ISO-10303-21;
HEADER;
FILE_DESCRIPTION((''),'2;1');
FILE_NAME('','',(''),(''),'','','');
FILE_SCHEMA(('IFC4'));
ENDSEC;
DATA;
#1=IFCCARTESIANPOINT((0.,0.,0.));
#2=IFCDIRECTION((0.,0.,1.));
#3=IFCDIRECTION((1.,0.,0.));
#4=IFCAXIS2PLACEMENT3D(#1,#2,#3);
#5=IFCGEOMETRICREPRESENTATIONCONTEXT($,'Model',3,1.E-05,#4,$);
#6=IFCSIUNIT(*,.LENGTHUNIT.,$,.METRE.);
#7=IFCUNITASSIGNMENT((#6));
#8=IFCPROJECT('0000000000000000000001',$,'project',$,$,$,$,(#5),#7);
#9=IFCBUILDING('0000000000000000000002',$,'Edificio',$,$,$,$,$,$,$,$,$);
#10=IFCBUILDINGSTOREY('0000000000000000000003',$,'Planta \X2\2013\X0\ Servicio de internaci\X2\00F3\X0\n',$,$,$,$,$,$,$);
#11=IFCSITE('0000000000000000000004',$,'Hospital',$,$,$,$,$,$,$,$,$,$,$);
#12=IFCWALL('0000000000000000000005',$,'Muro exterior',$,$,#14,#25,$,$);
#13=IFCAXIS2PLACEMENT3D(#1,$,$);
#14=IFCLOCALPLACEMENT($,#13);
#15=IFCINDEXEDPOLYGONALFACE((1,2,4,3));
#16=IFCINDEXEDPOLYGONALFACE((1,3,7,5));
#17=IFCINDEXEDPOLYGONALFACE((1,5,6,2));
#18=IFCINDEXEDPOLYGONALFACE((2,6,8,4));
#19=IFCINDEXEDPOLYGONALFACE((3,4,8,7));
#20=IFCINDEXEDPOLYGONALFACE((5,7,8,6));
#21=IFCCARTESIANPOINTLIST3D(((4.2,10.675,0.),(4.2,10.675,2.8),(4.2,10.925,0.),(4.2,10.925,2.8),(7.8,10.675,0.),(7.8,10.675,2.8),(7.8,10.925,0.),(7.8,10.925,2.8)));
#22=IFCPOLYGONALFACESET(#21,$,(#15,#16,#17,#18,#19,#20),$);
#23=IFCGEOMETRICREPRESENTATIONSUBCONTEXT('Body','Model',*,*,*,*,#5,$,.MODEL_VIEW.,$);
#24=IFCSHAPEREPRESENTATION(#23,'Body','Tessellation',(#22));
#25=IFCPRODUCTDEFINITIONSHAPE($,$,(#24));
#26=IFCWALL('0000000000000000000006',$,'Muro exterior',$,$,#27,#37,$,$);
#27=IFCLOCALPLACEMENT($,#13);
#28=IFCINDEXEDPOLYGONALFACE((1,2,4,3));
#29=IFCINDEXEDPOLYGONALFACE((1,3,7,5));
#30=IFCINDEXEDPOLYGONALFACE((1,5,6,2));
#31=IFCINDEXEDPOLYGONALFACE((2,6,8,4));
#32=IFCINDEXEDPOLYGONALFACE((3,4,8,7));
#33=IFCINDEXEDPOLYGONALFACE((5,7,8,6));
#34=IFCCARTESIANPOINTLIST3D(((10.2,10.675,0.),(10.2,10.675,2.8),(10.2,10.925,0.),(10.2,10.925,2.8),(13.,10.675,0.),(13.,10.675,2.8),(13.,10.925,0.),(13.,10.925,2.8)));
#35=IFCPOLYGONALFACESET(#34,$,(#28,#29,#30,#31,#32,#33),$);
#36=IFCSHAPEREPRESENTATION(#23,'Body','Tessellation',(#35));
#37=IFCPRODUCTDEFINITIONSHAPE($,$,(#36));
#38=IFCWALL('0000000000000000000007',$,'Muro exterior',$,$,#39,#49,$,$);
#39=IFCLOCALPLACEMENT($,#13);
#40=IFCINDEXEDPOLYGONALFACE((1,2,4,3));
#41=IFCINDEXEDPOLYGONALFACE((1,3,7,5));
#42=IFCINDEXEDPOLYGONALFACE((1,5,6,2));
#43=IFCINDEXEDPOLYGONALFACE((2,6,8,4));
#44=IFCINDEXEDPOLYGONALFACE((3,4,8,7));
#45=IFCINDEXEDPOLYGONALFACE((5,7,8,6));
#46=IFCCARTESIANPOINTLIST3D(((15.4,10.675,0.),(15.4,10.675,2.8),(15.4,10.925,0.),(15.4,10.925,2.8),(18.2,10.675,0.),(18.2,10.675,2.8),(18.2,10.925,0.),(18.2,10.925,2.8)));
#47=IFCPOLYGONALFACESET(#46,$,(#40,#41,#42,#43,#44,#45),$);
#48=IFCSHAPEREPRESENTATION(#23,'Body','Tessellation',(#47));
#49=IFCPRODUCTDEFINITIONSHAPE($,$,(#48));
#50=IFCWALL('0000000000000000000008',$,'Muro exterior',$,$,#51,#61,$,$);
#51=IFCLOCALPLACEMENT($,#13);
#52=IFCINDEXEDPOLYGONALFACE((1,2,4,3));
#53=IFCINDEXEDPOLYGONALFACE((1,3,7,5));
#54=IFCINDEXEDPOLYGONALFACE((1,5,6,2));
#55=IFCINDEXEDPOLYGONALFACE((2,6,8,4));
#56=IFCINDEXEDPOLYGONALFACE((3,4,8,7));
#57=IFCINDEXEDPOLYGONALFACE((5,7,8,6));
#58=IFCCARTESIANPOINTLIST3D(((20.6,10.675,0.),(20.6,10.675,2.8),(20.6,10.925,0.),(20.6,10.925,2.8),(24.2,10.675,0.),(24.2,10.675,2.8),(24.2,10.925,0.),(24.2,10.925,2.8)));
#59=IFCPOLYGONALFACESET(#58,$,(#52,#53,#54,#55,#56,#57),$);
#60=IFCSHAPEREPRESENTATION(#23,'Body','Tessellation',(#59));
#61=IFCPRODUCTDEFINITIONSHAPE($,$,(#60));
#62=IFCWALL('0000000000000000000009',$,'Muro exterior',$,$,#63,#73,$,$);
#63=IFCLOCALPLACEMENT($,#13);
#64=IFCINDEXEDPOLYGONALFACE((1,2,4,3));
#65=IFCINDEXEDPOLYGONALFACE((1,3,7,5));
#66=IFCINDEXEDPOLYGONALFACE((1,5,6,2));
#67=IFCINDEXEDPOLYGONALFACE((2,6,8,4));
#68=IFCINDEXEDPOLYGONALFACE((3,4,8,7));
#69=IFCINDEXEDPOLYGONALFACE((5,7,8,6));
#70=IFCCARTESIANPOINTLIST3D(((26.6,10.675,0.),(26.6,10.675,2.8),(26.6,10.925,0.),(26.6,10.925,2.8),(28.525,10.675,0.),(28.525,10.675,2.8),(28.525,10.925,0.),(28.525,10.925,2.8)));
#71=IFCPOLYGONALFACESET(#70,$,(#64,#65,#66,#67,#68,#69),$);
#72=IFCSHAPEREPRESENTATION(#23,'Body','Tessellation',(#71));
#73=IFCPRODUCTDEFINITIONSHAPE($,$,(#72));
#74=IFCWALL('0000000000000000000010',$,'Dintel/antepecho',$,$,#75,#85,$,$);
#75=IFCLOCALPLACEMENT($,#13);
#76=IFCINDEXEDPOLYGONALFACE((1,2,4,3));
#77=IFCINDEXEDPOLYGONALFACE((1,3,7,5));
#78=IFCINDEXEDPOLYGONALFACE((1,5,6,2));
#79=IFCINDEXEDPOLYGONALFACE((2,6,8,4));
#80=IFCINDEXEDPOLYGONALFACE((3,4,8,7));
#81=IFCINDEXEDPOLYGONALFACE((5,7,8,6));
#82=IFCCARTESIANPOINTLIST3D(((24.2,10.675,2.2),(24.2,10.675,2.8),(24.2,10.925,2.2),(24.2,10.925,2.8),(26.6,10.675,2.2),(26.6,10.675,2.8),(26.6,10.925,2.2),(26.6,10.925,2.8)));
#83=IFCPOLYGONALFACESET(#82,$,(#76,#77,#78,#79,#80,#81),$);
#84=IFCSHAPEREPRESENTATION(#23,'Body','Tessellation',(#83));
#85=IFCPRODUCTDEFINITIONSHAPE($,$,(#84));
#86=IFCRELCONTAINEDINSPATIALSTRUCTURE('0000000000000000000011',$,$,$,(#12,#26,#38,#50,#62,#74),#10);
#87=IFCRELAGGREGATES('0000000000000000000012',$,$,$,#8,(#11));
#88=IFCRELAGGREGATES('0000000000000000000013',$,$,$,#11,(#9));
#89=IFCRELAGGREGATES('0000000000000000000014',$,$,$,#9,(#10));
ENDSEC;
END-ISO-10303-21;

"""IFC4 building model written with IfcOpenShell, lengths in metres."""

from ifc_helpers import new_model, si_unit, frame, origin_with_axes, context, subcontext, project, spatial, line, indexed_curve, outline, extrude, element, save


model = new_model("IFC4")

# Units and contexts
model_context = context("Model", 3, precision=1e-05, world=origin_with_axes())
body_context = subcontext(model_context, "Body", "Model", "MODEL_VIEW")
ifc_project = project(units=[si_unit("LENGTHUNIT", "METRE")], contexts=[model_context])

# Site, building, storey
site = spatial("IfcSite", under=ifc_project, Name="Hospital")
building = spatial("IfcBuilding", under=site, Name="Edificio")
storey = spatial("IfcBuildingStorey", under=building, Name="Planta – Servicio de internación")

# Walls
element("IfcWall", 1, inside=storey, Name="Muro exterior", context=body_context, shape_type="SweptSolid", body=[
    extrude(outline(indexed_curve([(0.0, 0.0), (3.6, 0.0), (3.6, 0.25), (0.0, 0.25)], segments=[line(1, 2, 3, 4, 1)])), frame((4.2, 10.675, 0.0), z_axis=(0.0, 0.0, 1.0), x_axis=(1.0, 0.0, 0.0)), (0.0, 0.0, 1.0), 2.8),
])
element("IfcWall", 2, inside=storey, Name="Muro exterior", context=body_context, shape_type="SweptSolid", body=[
    extrude(outline(indexed_curve([(0.0, 0.0), (2.8, 0.0), (2.8, 0.25), (0.0, 0.25)], segments=[line(1, 2, 3, 4, 1)])), frame((10.2, 10.675, 0.0), z_axis=(0.0, 0.0, 1.0), x_axis=(1.0, 0.0, 0.0)), (0.0, 0.0, 1.0), 2.8),
])
element("IfcWall", 3, inside=storey, Name="Muro exterior", context=body_context, shape_type="SweptSolid", body=[
    extrude(outline(indexed_curve([(0.0, 0.0), (2.8, 0.0), (2.8, 0.25), (0.0, 0.25)], segments=[line(1, 2, 3, 4, 1)])), frame((15.4, 10.675, 0.0), z_axis=(0.0, 0.0, 1.0), x_axis=(1.0, 0.0, 0.0)), (0.0, 0.0, 1.0), 2.8),
])
element("IfcWall", 4, inside=storey, Name="Muro exterior", context=body_context, shape_type="SweptSolid", body=[
    extrude(outline(indexed_curve([(0.0, 0.0), (3.6, 0.0), (3.6, 0.25), (0.0, 0.25)], segments=[line(1, 2, 3, 4, 1)])), frame((20.6, 10.675, 0.0), z_axis=(0.0, 0.0, 1.0), x_axis=(1.0, 0.0, 0.0)), (0.0, 0.0, 1.0), 2.8),
])
element("IfcWall", 5, inside=storey, Name="Muro exterior", context=body_context, shape_type="SweptSolid", body=[
    extrude(outline(indexed_curve([(0.0, 0.0), (1.925, 0.0), (1.925, 0.25), (0.0, 0.25)], segments=[line(1, 2, 3, 4, 1)])), frame((26.6, 10.675, 0.0), z_axis=(0.0, 0.0, 1.0), x_axis=(1.0, 0.0, 0.0)), (0.0, 0.0, 1.0), 2.8),
])
element("IfcWall", 6, inside=storey, Name="Dintel/antepecho", context=body_context, shape_type="SweptSolid", body=[
    extrude(outline(indexed_curve([(0.0, 0.0), (2.4, 0.0), (2.4, 0.25), (0.0, 0.25)], segments=[line(1, 2, 3, 4, 1)])), frame((24.2, 10.675, 2.2), z_axis=(0.0, 0.0, 1.0), x_axis=(1.0, 0.0, 0.0)), (0.0, 0.0, 1.0), 0.6),
])

save(model, "model.ifc")
